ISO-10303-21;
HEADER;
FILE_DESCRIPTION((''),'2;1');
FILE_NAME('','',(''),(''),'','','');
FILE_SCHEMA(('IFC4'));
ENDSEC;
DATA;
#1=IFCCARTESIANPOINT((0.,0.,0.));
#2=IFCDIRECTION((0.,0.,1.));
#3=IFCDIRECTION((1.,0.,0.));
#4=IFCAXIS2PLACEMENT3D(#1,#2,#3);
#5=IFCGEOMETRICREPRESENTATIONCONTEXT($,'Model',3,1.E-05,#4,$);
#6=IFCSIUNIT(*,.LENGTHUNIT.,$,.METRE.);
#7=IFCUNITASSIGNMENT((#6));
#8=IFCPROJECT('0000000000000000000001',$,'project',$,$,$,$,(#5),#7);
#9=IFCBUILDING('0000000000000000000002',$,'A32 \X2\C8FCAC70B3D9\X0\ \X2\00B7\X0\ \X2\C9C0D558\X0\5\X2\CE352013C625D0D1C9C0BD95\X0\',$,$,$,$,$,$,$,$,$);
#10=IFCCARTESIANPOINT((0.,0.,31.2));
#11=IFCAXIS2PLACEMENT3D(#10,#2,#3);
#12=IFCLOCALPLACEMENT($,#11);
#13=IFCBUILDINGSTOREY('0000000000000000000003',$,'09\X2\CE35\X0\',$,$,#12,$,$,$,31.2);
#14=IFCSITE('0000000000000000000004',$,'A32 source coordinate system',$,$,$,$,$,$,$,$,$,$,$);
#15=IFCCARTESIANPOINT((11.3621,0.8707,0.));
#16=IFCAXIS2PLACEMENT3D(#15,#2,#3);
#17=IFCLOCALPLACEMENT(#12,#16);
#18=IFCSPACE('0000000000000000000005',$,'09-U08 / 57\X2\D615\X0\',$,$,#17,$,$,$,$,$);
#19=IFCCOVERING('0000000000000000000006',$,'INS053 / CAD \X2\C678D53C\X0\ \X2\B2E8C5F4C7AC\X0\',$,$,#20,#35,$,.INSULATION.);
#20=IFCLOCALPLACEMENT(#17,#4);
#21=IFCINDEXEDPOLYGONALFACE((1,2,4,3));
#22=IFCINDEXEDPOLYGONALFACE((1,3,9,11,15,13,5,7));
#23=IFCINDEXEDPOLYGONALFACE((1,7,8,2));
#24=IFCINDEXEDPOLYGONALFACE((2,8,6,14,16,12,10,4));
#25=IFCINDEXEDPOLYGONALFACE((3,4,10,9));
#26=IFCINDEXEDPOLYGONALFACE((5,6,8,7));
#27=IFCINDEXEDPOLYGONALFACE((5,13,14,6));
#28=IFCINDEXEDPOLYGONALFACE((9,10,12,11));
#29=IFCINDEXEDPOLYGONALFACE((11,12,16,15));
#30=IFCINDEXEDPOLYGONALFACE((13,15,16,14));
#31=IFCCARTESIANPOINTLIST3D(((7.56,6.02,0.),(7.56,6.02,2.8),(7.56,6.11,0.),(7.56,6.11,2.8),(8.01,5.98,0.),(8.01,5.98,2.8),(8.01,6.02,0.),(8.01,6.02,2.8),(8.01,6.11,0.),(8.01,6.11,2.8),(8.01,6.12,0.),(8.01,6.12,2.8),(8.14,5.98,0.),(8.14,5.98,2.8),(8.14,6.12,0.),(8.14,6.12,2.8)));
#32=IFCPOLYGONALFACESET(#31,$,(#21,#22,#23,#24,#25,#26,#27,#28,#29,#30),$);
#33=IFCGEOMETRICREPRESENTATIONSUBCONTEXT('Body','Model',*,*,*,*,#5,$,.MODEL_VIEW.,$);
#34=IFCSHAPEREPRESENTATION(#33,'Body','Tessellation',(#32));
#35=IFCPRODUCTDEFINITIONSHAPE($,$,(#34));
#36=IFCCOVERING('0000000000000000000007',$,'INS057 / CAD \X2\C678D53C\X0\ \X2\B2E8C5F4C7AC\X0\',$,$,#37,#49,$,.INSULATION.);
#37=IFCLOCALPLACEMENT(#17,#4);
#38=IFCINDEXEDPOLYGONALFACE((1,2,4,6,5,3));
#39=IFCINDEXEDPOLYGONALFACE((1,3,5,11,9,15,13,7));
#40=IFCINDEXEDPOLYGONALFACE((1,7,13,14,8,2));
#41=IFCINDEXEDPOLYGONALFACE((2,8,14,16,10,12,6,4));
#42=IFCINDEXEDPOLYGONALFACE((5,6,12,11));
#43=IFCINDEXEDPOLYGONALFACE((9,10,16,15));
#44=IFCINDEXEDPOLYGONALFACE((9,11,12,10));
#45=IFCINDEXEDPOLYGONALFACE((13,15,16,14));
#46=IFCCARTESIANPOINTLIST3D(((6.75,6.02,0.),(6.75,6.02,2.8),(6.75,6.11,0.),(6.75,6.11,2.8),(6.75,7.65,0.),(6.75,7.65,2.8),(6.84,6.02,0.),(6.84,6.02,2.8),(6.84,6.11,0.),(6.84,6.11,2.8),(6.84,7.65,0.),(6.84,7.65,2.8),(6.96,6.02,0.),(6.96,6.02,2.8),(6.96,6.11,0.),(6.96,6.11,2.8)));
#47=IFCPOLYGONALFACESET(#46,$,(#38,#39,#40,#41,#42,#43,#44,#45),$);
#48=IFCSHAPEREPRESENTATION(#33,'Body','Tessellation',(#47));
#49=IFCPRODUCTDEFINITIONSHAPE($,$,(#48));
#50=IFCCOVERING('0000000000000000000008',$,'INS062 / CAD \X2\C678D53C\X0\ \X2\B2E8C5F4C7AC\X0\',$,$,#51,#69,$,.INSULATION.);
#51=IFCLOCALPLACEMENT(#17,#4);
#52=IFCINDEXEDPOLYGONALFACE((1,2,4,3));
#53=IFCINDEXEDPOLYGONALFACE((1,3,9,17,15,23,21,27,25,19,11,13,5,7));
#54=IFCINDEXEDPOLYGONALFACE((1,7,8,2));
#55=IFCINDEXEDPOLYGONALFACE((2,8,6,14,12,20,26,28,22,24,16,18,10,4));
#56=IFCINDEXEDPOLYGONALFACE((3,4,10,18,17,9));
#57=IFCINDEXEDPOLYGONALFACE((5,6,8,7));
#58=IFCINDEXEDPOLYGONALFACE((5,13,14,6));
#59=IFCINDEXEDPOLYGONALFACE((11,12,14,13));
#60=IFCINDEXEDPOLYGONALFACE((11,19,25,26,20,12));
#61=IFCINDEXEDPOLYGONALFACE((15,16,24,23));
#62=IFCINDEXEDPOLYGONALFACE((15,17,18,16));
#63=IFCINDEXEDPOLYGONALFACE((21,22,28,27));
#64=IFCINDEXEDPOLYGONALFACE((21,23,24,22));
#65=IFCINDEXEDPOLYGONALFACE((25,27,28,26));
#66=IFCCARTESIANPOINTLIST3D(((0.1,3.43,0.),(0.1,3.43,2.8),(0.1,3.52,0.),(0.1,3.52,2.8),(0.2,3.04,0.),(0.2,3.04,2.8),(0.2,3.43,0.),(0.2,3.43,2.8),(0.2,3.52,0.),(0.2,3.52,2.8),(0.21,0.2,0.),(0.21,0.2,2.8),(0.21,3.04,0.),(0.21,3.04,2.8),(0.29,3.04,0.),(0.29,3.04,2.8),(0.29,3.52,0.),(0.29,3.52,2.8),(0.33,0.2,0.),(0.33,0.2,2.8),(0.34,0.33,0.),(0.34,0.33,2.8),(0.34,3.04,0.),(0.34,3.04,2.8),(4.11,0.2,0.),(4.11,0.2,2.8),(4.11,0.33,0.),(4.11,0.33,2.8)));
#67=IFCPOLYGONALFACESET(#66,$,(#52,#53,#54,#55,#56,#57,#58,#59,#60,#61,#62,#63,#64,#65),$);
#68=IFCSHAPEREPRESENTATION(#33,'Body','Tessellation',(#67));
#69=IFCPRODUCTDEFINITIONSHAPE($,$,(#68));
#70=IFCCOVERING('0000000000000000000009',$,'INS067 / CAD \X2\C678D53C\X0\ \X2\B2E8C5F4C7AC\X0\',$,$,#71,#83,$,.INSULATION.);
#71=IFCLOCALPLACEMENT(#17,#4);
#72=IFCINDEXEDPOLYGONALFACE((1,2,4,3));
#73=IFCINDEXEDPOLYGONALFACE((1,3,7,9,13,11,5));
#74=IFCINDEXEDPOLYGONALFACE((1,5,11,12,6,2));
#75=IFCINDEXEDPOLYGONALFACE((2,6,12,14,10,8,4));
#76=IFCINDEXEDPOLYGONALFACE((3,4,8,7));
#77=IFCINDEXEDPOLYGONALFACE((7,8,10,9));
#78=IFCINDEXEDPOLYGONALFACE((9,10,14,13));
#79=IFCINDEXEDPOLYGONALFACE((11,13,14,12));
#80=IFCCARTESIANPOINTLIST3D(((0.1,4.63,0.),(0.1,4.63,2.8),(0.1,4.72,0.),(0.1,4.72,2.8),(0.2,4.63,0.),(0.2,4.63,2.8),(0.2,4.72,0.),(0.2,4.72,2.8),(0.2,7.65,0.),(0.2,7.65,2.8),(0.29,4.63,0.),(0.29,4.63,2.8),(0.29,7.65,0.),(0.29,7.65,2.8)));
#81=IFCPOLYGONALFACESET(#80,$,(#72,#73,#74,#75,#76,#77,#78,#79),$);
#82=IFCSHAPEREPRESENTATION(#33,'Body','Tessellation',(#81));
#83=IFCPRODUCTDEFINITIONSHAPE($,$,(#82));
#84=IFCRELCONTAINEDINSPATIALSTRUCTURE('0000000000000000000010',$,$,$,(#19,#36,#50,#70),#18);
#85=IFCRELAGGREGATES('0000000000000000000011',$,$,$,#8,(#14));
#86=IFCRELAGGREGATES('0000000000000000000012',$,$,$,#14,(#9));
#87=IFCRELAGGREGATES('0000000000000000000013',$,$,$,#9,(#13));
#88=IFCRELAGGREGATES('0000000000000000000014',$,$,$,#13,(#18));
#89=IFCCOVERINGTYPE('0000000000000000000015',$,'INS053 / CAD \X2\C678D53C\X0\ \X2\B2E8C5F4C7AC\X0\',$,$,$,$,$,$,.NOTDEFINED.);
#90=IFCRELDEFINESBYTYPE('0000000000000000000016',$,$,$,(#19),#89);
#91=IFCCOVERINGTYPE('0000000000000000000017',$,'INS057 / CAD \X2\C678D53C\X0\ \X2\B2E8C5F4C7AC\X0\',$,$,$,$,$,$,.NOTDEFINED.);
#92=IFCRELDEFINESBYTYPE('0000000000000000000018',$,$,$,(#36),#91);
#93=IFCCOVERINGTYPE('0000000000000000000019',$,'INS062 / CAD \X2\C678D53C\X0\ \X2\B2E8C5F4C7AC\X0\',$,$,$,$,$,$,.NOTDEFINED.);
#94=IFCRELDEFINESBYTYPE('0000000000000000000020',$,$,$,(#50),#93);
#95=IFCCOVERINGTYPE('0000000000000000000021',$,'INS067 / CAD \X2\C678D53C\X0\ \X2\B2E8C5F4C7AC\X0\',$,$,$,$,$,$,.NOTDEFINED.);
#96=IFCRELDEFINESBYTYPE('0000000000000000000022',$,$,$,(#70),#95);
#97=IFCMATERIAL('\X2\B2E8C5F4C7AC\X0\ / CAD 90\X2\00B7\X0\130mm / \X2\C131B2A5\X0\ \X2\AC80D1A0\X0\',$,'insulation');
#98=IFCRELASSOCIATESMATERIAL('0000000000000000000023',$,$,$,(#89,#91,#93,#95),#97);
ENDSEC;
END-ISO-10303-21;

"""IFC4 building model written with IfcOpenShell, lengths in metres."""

from ifc_helpers import new_model, si_unit, frame, origin, origin_with_axes, place, context, subcontext, project, spatial, polyline, outline, extrude, source, transform, mapped, material, type_object, type_shapes, element, save


model = new_model("IFC4")

# Units and contexts
model_context = context("Model", 3, precision=1e-05, world=origin_with_axes())
body_context = subcontext(model_context, "Body", "Model", "MODEL_VIEW")
ifc_project = project(units=[si_unit("LENGTHUNIT", "METRE")], contexts=[model_context])

# Site, building, storey, space
site = spatial("IfcSite", under=ifc_project, Name="A32 source coordinate system")
building = spatial("IfcBuilding", under=site, Name="A32 주거동 · 지하5층–옥탑지붕")
storey_placement = place(None, frame((0.0, 0.0, 31.2), z_axis=(0.0, 0.0, 1.0), x_axis=(1.0, 0.0, 0.0)))
storey = spatial("IfcBuildingStorey", under=building, at=storey_placement, Name="09층", Elevation=31.2)
space_1_placement = place(storey_placement, frame((11.3621, 0.8707, 0.0), z_axis=(0.0, 0.0, 1.0), x_axis=(1.0, 0.0, 0.0)))
space_1 = spatial("IfcSpace", under=storey, at=space_1_placement, Name="09-U08 / 57형")

# Coverings
ifc_material = material(Name="단열재 / CAD 90·130mm / 성능 검토", Category="insulation")
covering_type_1 = type_object("IfcCoveringType", Name="INS053 / CAD 외피 단열재", PredefinedType="NOTDEFINED", material=ifc_material)
shared_shape_1 = source(origin(), body_context, "Body", "SweptSolid", [
    extrude(outline(polyline([(8.01, 6.12), (8.14, 6.12), (8.14, 5.98), (8.01, 5.98), (8.01, 6.02), (7.56, 6.02), (7.56, 6.11), (8.01, 6.11), (8.01, 6.12)])), origin(), (0.0, 0.0, 1.0), 2.8),
])
type_shapes(covering_type_1, [shared_shape_1])
covering_1_placement = place(space_1_placement, origin_with_axes())
element("IfcCovering", 1, at=covering_1_placement, inside=space_1, type_object=covering_type_1, Name="INS053 / CAD 외피 단열재", PredefinedType="INSULATION", context=body_context, shape_type="MappedRepresentation", body=[
    mapped(shared_shape_1, transform((0.0, 0.0, 0.0), scale=1.0)),
])
covering_type_2 = type_object("IfcCoveringType", Name="INS057 / CAD 외피 단열재", PredefinedType="NOTDEFINED", material=ifc_material)
shared_shape_2 = source(origin(), body_context, "Body", "SweptSolid", [
    extrude(outline(polyline([(6.84, 6.11), (6.96, 6.11), (6.96, 6.02), (6.84, 6.02), (6.75, 6.02), (6.75, 6.11), (6.75, 7.65), (6.84, 7.65), (6.84, 6.11)])), origin(), (0.0, 0.0, 1.0), 2.8),
])
type_shapes(covering_type_2, [shared_shape_2])
covering_2_placement = place(space_1_placement, origin_with_axes())
element("IfcCovering", 2, at=covering_2_placement, inside=space_1, type_object=covering_type_2, Name="INS057 / CAD 외피 단열재", PredefinedType="INSULATION", context=body_context, shape_type="MappedRepresentation", body=[
    mapped(shared_shape_2, transform((0.0, 0.0, 0.0), scale=1.0)),
])
covering_type_3 = type_object("IfcCoveringType", Name="INS062 / CAD 외피 단열재", PredefinedType="NOTDEFINED", material=ifc_material)
shared_shape_3 = source(origin(), body_context, "Body", "SweptSolid", [
    extrude(outline(polyline([(4.11, 0.2), (0.33, 0.2), (0.21, 0.2), (0.21, 3.04), (0.2, 3.04), (0.2, 3.43), (0.1, 3.43), (0.1, 3.52), (0.2, 3.52), (0.29, 3.52), (0.29, 3.04), (0.34, 3.04), (0.34, 0.33), (4.11, 0.33), (4.11, 0.2)])), origin(), (0.0, 0.0, 1.0), 2.8),
])
type_shapes(covering_type_3, [shared_shape_3])
covering_3_placement = place(space_1_placement, origin_with_axes())
element("IfcCovering", 3, at=covering_3_placement, inside=space_1, type_object=covering_type_3, Name="INS062 / CAD 외피 단열재", PredefinedType="INSULATION", context=body_context, shape_type="MappedRepresentation", body=[
    mapped(shared_shape_3, transform((0.0, 0.0, 0.0), scale=1.0)),
])
covering_type_4 = type_object("IfcCoveringType", Name="INS067 / CAD 외피 단열재", PredefinedType="NOTDEFINED", material=ifc_material)
shared_shape_4 = source(origin(), body_context, "Body", "SweptSolid", [
    extrude(outline(polyline([(0.1, 4.72), (0.2, 4.72), (0.2, 7.65), (0.29, 7.65), (0.29, 4.63), (0.2, 4.63), (0.1, 4.63), (0.1, 4.72)])), origin(), (0.0, 0.0, 1.0), 2.8),
])
type_shapes(covering_type_4, [shared_shape_4])
covering_4_placement = place(space_1_placement, origin_with_axes())
element("IfcCovering", 4, at=covering_4_placement, inside=space_1, type_object=covering_type_4, Name="INS067 / CAD 외피 단열재", PredefinedType="INSULATION", context=body_context, shape_type="MappedRepresentation", body=[
    mapped(shared_shape_4, transform((0.0, 0.0, 0.0), scale=1.0)),
])

save(model, "model.ifc")
